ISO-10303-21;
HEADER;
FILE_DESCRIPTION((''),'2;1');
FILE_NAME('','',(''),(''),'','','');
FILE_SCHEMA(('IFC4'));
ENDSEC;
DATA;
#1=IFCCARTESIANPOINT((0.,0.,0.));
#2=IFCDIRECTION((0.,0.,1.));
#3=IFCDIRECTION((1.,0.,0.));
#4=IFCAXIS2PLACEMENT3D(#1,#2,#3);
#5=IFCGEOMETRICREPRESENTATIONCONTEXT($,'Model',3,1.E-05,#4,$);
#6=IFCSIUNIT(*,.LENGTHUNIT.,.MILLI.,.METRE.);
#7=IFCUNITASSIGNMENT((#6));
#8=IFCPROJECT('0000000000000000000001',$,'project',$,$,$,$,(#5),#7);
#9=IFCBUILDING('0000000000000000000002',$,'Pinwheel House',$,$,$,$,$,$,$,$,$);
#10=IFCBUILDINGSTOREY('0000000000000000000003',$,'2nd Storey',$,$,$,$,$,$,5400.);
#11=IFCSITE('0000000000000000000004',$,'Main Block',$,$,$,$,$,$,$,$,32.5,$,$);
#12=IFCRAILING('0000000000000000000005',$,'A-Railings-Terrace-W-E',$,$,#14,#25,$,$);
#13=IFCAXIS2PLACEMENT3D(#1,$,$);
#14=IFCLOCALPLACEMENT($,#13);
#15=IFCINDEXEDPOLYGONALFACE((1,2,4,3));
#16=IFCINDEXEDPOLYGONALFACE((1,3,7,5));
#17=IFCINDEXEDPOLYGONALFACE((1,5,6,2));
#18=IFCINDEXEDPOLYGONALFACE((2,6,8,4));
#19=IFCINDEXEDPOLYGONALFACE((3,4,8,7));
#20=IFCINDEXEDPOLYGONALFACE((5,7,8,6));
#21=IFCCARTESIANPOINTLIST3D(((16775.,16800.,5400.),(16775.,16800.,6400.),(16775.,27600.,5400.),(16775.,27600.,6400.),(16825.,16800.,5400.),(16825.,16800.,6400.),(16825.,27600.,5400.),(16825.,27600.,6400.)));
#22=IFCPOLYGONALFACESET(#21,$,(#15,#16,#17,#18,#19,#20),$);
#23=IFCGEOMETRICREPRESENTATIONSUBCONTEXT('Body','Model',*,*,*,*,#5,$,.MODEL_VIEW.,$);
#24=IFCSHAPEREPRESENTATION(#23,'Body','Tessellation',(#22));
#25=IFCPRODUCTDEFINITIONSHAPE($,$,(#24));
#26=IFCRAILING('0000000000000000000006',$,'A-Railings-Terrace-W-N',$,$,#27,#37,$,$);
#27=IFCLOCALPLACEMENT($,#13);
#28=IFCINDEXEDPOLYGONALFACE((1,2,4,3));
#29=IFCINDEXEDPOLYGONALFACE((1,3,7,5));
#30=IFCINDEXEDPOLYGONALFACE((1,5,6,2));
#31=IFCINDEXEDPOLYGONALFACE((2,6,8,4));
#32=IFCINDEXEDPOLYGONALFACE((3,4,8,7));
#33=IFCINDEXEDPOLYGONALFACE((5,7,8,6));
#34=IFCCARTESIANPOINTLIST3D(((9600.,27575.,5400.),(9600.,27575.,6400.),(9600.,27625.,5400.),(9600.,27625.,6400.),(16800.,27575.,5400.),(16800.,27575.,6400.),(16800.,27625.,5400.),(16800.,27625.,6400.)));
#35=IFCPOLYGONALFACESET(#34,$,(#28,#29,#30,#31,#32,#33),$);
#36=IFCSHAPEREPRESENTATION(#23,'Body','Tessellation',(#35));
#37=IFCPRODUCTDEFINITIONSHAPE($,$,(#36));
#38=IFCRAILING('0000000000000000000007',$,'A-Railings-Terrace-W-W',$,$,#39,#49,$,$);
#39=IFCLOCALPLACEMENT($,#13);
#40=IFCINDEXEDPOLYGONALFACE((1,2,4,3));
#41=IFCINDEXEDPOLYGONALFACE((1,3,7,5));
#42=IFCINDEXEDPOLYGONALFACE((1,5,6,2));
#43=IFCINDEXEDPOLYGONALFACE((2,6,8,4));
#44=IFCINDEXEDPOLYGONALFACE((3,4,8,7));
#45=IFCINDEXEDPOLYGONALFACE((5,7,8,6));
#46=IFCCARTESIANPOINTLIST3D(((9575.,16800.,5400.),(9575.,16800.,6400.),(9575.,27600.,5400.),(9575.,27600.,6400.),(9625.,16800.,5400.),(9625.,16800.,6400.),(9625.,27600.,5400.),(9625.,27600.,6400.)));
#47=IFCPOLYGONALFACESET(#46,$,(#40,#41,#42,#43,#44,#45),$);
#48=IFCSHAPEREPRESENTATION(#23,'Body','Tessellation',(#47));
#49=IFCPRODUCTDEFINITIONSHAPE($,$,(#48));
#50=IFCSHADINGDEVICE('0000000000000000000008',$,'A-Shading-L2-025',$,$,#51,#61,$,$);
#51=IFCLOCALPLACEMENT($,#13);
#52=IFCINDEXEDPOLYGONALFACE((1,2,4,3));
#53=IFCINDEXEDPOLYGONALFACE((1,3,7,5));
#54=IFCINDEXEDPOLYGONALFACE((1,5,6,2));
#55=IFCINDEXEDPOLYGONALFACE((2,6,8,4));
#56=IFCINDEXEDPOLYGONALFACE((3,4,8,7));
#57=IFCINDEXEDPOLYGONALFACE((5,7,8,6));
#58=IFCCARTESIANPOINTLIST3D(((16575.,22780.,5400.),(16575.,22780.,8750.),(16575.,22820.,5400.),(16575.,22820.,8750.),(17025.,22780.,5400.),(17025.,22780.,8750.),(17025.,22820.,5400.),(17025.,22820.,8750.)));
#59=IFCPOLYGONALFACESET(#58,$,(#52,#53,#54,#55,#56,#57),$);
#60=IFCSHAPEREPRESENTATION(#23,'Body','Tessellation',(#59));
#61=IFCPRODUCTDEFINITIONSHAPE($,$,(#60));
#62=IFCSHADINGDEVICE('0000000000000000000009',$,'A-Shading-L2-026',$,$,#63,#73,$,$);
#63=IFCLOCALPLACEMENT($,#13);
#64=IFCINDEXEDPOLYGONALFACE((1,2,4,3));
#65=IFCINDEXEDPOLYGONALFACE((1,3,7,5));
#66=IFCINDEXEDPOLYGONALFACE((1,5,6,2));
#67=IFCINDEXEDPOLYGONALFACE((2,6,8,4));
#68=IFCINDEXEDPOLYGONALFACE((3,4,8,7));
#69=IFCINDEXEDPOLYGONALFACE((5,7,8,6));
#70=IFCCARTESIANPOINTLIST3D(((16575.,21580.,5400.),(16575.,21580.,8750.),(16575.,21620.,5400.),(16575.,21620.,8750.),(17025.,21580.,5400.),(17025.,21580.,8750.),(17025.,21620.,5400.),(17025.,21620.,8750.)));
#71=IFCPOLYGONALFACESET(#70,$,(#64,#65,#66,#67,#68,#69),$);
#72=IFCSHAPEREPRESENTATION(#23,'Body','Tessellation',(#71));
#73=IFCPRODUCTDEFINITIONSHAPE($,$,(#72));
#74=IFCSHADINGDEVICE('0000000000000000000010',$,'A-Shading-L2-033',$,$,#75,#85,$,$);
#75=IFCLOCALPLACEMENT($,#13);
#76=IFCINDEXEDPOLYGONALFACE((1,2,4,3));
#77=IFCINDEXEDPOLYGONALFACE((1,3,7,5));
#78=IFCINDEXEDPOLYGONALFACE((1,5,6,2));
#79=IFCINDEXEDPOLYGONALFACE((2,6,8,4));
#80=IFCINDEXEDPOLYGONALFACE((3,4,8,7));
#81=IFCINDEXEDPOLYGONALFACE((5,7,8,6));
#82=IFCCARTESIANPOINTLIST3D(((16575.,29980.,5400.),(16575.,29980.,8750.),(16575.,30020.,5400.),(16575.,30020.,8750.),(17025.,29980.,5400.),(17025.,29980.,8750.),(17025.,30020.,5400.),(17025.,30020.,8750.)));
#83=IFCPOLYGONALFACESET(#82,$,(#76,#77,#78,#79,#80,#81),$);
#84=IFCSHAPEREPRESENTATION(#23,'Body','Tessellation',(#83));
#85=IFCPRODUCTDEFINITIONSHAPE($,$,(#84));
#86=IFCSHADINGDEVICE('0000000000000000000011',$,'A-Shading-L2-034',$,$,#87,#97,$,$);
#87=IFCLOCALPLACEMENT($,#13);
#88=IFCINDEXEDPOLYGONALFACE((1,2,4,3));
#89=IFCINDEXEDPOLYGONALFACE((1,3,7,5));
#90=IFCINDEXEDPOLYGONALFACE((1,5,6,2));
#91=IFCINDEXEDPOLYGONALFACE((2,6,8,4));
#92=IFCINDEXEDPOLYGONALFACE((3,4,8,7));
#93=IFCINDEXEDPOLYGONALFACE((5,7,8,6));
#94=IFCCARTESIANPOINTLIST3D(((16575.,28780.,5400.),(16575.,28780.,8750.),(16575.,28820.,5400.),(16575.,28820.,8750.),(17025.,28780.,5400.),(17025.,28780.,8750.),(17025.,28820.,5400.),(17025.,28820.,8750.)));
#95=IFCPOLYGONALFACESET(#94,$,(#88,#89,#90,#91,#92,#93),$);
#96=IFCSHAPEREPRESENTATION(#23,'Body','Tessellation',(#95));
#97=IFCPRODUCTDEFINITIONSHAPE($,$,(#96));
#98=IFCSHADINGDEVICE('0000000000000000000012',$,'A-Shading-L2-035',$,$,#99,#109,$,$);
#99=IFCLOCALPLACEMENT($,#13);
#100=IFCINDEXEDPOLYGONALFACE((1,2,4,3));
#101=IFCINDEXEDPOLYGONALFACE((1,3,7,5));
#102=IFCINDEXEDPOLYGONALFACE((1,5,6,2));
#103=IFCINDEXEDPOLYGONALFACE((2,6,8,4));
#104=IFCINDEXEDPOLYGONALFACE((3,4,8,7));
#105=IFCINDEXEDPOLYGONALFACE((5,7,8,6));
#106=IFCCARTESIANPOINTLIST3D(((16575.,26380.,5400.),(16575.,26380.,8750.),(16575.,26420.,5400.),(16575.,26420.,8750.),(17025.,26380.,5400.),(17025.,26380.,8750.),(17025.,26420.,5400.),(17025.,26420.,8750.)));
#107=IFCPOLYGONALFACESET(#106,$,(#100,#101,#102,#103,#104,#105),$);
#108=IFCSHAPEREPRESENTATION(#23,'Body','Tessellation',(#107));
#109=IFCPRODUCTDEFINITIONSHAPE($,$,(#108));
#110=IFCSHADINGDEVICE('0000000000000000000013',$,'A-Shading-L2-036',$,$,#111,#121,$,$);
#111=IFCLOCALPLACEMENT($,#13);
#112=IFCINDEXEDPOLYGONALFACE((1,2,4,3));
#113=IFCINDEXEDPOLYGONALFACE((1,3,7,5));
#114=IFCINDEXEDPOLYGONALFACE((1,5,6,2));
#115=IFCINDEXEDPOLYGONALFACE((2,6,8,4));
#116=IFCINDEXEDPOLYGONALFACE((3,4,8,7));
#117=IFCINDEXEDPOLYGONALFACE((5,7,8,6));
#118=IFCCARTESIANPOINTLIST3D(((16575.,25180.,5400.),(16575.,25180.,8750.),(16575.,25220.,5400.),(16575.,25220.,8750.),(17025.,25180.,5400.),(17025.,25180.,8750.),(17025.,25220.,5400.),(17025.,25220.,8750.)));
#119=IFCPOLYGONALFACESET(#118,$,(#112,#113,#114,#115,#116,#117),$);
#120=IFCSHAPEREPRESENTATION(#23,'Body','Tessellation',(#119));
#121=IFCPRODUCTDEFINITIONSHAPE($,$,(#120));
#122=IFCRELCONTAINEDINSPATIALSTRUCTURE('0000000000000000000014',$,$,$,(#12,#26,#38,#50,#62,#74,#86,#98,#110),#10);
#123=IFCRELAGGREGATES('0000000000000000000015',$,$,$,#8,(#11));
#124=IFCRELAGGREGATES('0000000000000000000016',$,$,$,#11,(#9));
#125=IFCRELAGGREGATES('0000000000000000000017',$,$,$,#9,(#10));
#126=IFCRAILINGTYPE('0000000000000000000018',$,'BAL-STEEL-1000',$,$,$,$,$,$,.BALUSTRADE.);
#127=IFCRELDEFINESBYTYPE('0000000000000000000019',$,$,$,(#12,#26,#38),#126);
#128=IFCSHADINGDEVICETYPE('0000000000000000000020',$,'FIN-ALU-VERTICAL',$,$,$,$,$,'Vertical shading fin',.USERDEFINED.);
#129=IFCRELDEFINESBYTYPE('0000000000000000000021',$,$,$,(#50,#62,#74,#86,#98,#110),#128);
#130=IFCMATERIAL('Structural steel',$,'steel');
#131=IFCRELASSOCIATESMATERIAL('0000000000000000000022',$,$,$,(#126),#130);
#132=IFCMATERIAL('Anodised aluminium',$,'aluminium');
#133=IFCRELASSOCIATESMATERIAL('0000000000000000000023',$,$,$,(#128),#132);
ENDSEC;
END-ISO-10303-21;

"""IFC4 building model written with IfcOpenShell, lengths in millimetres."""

from ifc_helpers import new_model, si_unit, frame, origin_with_axes, place, context, subcontext, project, spatial, indexed_curve, outline, extrude, material, type_object, element, save


model = new_model("IFC4")

# Units and contexts
model_context = context("Model", 3, precision=1e-05, world=origin_with_axes())
body_context = subcontext(model_context, "Body", "Model", "MODEL_VIEW")
ifc_project = project(units=[si_unit("LENGTHUNIT", "METRE", prefix="MILLI")], contexts=[model_context])

# Site, building, storey
site = spatial("IfcSite", under=ifc_project, Name="Main Block", RefElevation=32.5)
building = spatial("IfcBuilding", under=site, Name="Pinwheel House")
storey = spatial("IfcBuildingStorey", under=building, Name="2nd Storey", Elevation=5400.0)

# Shared definitions
ifc_material_1 = material(Name="Structural steel", Category="steel")

# Shared definitions
ifc_material_2 = material(Name="Anodised aluminium", Category="aluminium")

# Railings
railing_type = type_object("IfcRailingType", Name="BAL-STEEL-1000", PredefinedType="BALUSTRADE", material=ifc_material_1)
railing_1_placement = place(None, frame((16800.0, 22200.0, 5400.0), z_axis=(0.0, 0.0, 1.0), x_axis=(0.0, 1.0, 0.0)))
element("IfcRailing", 1, at=railing_1_placement, inside=storey, type_object=railing_type, Name="A-Railings-Terrace-W-E", context=body_context, shape_type="SweptSolid", body=[
    extrude(outline(indexed_curve([(-5400.0, -25.0), (5400.0, -25.0), (5400.0, 25.0), (-5400.0, 25.0)])), None, (0.0, 0.0, 1.0), 1000.0),
])
railing_2_placement = place(None, frame((13200.0, 27600.0, 5400.0), z_axis=(0.0, 0.0, 1.0), x_axis=(-1.0, 0.0, 0.0)))
element("IfcRailing", 2, at=railing_2_placement, inside=storey, type_object=railing_type, Name="A-Railings-Terrace-W-N", context=body_context, shape_type="SweptSolid", body=[
    extrude(outline(indexed_curve([(-3600.0, -25.0), (3600.0, -25.0), (3600.0, 25.0), (-3600.0, 25.0)])), None, (0.0, 0.0, 1.0), 1000.0),
])
railing_3_placement = place(None, frame((9600.0, 22200.0, 5400.0), z_axis=(0.0, 0.0, 1.0), x_axis=(0.0, -1.0, 0.0)))
element("IfcRailing", 3, at=railing_3_placement, inside=storey, type_object=railing_type, Name="A-Railings-Terrace-W-W", context=body_context, shape_type="SweptSolid", body=[
    extrude(outline(indexed_curve([(-5400.0, -25.0), (5400.0, -25.0), (5400.0, 25.0), (-5400.0, 25.0)])), None, (0.0, 0.0, 1.0), 1000.0),
])

# Shading devices
shading_device_type = type_object("IfcShadingDeviceType", Name="FIN-ALU-VERTICAL", ElementType="Vertical shading fin", PredefinedType="USERDEFINED", material=ifc_material_2)
for number, where, z_axis, x_axis, name in (
    (4, (16800.0, 22800.0, 5400.0), (0.0, 0.0, 1.0), (0.0, -1.0, 0.0), "A-Shading-L2-025"),
    (5, (16800.0, 21600.0, 5400.0), (0.0, 0.0, 1.0), (0.0, -1.0, 0.0), "A-Shading-L2-026"),
    (6, (16800.0, 30000.0, 5400.0), (0.0, 0.0, 1.0), (0.0, -1.0, 0.0), "A-Shading-L2-033"),
    (7, (16800.0, 28800.0, 5400.0), (0.0, 0.0, 1.0), (0.0, -1.0, 0.0), "A-Shading-L2-034"),
    (8, (16800.0, 26400.0, 5400.0), (0.0, 0.0, 1.0), (0.0, -1.0, 0.0), "A-Shading-L2-035"),
    (9, (16800.0, 25200.0, 5400.0), (0.0, 0.0, 1.0), (0.0, -1.0, 0.0), "A-Shading-L2-036"),
):
    element("IfcShadingDevice", number, at=place(None, frame(where, z_axis=z_axis, x_axis=x_axis)), inside=storey, type_object=shading_device_type, Name=name, context=body_context, shape_type="SweptSolid", body=[
        extrude(outline(indexed_curve([(-20.0, -225.0), (20.0, -225.0), (20.0, 225.0), (-20.0, 225.0)])), None, (0.0, 0.0, 1.0), 3350.0),
    ])

save(model, "model.ifc")
